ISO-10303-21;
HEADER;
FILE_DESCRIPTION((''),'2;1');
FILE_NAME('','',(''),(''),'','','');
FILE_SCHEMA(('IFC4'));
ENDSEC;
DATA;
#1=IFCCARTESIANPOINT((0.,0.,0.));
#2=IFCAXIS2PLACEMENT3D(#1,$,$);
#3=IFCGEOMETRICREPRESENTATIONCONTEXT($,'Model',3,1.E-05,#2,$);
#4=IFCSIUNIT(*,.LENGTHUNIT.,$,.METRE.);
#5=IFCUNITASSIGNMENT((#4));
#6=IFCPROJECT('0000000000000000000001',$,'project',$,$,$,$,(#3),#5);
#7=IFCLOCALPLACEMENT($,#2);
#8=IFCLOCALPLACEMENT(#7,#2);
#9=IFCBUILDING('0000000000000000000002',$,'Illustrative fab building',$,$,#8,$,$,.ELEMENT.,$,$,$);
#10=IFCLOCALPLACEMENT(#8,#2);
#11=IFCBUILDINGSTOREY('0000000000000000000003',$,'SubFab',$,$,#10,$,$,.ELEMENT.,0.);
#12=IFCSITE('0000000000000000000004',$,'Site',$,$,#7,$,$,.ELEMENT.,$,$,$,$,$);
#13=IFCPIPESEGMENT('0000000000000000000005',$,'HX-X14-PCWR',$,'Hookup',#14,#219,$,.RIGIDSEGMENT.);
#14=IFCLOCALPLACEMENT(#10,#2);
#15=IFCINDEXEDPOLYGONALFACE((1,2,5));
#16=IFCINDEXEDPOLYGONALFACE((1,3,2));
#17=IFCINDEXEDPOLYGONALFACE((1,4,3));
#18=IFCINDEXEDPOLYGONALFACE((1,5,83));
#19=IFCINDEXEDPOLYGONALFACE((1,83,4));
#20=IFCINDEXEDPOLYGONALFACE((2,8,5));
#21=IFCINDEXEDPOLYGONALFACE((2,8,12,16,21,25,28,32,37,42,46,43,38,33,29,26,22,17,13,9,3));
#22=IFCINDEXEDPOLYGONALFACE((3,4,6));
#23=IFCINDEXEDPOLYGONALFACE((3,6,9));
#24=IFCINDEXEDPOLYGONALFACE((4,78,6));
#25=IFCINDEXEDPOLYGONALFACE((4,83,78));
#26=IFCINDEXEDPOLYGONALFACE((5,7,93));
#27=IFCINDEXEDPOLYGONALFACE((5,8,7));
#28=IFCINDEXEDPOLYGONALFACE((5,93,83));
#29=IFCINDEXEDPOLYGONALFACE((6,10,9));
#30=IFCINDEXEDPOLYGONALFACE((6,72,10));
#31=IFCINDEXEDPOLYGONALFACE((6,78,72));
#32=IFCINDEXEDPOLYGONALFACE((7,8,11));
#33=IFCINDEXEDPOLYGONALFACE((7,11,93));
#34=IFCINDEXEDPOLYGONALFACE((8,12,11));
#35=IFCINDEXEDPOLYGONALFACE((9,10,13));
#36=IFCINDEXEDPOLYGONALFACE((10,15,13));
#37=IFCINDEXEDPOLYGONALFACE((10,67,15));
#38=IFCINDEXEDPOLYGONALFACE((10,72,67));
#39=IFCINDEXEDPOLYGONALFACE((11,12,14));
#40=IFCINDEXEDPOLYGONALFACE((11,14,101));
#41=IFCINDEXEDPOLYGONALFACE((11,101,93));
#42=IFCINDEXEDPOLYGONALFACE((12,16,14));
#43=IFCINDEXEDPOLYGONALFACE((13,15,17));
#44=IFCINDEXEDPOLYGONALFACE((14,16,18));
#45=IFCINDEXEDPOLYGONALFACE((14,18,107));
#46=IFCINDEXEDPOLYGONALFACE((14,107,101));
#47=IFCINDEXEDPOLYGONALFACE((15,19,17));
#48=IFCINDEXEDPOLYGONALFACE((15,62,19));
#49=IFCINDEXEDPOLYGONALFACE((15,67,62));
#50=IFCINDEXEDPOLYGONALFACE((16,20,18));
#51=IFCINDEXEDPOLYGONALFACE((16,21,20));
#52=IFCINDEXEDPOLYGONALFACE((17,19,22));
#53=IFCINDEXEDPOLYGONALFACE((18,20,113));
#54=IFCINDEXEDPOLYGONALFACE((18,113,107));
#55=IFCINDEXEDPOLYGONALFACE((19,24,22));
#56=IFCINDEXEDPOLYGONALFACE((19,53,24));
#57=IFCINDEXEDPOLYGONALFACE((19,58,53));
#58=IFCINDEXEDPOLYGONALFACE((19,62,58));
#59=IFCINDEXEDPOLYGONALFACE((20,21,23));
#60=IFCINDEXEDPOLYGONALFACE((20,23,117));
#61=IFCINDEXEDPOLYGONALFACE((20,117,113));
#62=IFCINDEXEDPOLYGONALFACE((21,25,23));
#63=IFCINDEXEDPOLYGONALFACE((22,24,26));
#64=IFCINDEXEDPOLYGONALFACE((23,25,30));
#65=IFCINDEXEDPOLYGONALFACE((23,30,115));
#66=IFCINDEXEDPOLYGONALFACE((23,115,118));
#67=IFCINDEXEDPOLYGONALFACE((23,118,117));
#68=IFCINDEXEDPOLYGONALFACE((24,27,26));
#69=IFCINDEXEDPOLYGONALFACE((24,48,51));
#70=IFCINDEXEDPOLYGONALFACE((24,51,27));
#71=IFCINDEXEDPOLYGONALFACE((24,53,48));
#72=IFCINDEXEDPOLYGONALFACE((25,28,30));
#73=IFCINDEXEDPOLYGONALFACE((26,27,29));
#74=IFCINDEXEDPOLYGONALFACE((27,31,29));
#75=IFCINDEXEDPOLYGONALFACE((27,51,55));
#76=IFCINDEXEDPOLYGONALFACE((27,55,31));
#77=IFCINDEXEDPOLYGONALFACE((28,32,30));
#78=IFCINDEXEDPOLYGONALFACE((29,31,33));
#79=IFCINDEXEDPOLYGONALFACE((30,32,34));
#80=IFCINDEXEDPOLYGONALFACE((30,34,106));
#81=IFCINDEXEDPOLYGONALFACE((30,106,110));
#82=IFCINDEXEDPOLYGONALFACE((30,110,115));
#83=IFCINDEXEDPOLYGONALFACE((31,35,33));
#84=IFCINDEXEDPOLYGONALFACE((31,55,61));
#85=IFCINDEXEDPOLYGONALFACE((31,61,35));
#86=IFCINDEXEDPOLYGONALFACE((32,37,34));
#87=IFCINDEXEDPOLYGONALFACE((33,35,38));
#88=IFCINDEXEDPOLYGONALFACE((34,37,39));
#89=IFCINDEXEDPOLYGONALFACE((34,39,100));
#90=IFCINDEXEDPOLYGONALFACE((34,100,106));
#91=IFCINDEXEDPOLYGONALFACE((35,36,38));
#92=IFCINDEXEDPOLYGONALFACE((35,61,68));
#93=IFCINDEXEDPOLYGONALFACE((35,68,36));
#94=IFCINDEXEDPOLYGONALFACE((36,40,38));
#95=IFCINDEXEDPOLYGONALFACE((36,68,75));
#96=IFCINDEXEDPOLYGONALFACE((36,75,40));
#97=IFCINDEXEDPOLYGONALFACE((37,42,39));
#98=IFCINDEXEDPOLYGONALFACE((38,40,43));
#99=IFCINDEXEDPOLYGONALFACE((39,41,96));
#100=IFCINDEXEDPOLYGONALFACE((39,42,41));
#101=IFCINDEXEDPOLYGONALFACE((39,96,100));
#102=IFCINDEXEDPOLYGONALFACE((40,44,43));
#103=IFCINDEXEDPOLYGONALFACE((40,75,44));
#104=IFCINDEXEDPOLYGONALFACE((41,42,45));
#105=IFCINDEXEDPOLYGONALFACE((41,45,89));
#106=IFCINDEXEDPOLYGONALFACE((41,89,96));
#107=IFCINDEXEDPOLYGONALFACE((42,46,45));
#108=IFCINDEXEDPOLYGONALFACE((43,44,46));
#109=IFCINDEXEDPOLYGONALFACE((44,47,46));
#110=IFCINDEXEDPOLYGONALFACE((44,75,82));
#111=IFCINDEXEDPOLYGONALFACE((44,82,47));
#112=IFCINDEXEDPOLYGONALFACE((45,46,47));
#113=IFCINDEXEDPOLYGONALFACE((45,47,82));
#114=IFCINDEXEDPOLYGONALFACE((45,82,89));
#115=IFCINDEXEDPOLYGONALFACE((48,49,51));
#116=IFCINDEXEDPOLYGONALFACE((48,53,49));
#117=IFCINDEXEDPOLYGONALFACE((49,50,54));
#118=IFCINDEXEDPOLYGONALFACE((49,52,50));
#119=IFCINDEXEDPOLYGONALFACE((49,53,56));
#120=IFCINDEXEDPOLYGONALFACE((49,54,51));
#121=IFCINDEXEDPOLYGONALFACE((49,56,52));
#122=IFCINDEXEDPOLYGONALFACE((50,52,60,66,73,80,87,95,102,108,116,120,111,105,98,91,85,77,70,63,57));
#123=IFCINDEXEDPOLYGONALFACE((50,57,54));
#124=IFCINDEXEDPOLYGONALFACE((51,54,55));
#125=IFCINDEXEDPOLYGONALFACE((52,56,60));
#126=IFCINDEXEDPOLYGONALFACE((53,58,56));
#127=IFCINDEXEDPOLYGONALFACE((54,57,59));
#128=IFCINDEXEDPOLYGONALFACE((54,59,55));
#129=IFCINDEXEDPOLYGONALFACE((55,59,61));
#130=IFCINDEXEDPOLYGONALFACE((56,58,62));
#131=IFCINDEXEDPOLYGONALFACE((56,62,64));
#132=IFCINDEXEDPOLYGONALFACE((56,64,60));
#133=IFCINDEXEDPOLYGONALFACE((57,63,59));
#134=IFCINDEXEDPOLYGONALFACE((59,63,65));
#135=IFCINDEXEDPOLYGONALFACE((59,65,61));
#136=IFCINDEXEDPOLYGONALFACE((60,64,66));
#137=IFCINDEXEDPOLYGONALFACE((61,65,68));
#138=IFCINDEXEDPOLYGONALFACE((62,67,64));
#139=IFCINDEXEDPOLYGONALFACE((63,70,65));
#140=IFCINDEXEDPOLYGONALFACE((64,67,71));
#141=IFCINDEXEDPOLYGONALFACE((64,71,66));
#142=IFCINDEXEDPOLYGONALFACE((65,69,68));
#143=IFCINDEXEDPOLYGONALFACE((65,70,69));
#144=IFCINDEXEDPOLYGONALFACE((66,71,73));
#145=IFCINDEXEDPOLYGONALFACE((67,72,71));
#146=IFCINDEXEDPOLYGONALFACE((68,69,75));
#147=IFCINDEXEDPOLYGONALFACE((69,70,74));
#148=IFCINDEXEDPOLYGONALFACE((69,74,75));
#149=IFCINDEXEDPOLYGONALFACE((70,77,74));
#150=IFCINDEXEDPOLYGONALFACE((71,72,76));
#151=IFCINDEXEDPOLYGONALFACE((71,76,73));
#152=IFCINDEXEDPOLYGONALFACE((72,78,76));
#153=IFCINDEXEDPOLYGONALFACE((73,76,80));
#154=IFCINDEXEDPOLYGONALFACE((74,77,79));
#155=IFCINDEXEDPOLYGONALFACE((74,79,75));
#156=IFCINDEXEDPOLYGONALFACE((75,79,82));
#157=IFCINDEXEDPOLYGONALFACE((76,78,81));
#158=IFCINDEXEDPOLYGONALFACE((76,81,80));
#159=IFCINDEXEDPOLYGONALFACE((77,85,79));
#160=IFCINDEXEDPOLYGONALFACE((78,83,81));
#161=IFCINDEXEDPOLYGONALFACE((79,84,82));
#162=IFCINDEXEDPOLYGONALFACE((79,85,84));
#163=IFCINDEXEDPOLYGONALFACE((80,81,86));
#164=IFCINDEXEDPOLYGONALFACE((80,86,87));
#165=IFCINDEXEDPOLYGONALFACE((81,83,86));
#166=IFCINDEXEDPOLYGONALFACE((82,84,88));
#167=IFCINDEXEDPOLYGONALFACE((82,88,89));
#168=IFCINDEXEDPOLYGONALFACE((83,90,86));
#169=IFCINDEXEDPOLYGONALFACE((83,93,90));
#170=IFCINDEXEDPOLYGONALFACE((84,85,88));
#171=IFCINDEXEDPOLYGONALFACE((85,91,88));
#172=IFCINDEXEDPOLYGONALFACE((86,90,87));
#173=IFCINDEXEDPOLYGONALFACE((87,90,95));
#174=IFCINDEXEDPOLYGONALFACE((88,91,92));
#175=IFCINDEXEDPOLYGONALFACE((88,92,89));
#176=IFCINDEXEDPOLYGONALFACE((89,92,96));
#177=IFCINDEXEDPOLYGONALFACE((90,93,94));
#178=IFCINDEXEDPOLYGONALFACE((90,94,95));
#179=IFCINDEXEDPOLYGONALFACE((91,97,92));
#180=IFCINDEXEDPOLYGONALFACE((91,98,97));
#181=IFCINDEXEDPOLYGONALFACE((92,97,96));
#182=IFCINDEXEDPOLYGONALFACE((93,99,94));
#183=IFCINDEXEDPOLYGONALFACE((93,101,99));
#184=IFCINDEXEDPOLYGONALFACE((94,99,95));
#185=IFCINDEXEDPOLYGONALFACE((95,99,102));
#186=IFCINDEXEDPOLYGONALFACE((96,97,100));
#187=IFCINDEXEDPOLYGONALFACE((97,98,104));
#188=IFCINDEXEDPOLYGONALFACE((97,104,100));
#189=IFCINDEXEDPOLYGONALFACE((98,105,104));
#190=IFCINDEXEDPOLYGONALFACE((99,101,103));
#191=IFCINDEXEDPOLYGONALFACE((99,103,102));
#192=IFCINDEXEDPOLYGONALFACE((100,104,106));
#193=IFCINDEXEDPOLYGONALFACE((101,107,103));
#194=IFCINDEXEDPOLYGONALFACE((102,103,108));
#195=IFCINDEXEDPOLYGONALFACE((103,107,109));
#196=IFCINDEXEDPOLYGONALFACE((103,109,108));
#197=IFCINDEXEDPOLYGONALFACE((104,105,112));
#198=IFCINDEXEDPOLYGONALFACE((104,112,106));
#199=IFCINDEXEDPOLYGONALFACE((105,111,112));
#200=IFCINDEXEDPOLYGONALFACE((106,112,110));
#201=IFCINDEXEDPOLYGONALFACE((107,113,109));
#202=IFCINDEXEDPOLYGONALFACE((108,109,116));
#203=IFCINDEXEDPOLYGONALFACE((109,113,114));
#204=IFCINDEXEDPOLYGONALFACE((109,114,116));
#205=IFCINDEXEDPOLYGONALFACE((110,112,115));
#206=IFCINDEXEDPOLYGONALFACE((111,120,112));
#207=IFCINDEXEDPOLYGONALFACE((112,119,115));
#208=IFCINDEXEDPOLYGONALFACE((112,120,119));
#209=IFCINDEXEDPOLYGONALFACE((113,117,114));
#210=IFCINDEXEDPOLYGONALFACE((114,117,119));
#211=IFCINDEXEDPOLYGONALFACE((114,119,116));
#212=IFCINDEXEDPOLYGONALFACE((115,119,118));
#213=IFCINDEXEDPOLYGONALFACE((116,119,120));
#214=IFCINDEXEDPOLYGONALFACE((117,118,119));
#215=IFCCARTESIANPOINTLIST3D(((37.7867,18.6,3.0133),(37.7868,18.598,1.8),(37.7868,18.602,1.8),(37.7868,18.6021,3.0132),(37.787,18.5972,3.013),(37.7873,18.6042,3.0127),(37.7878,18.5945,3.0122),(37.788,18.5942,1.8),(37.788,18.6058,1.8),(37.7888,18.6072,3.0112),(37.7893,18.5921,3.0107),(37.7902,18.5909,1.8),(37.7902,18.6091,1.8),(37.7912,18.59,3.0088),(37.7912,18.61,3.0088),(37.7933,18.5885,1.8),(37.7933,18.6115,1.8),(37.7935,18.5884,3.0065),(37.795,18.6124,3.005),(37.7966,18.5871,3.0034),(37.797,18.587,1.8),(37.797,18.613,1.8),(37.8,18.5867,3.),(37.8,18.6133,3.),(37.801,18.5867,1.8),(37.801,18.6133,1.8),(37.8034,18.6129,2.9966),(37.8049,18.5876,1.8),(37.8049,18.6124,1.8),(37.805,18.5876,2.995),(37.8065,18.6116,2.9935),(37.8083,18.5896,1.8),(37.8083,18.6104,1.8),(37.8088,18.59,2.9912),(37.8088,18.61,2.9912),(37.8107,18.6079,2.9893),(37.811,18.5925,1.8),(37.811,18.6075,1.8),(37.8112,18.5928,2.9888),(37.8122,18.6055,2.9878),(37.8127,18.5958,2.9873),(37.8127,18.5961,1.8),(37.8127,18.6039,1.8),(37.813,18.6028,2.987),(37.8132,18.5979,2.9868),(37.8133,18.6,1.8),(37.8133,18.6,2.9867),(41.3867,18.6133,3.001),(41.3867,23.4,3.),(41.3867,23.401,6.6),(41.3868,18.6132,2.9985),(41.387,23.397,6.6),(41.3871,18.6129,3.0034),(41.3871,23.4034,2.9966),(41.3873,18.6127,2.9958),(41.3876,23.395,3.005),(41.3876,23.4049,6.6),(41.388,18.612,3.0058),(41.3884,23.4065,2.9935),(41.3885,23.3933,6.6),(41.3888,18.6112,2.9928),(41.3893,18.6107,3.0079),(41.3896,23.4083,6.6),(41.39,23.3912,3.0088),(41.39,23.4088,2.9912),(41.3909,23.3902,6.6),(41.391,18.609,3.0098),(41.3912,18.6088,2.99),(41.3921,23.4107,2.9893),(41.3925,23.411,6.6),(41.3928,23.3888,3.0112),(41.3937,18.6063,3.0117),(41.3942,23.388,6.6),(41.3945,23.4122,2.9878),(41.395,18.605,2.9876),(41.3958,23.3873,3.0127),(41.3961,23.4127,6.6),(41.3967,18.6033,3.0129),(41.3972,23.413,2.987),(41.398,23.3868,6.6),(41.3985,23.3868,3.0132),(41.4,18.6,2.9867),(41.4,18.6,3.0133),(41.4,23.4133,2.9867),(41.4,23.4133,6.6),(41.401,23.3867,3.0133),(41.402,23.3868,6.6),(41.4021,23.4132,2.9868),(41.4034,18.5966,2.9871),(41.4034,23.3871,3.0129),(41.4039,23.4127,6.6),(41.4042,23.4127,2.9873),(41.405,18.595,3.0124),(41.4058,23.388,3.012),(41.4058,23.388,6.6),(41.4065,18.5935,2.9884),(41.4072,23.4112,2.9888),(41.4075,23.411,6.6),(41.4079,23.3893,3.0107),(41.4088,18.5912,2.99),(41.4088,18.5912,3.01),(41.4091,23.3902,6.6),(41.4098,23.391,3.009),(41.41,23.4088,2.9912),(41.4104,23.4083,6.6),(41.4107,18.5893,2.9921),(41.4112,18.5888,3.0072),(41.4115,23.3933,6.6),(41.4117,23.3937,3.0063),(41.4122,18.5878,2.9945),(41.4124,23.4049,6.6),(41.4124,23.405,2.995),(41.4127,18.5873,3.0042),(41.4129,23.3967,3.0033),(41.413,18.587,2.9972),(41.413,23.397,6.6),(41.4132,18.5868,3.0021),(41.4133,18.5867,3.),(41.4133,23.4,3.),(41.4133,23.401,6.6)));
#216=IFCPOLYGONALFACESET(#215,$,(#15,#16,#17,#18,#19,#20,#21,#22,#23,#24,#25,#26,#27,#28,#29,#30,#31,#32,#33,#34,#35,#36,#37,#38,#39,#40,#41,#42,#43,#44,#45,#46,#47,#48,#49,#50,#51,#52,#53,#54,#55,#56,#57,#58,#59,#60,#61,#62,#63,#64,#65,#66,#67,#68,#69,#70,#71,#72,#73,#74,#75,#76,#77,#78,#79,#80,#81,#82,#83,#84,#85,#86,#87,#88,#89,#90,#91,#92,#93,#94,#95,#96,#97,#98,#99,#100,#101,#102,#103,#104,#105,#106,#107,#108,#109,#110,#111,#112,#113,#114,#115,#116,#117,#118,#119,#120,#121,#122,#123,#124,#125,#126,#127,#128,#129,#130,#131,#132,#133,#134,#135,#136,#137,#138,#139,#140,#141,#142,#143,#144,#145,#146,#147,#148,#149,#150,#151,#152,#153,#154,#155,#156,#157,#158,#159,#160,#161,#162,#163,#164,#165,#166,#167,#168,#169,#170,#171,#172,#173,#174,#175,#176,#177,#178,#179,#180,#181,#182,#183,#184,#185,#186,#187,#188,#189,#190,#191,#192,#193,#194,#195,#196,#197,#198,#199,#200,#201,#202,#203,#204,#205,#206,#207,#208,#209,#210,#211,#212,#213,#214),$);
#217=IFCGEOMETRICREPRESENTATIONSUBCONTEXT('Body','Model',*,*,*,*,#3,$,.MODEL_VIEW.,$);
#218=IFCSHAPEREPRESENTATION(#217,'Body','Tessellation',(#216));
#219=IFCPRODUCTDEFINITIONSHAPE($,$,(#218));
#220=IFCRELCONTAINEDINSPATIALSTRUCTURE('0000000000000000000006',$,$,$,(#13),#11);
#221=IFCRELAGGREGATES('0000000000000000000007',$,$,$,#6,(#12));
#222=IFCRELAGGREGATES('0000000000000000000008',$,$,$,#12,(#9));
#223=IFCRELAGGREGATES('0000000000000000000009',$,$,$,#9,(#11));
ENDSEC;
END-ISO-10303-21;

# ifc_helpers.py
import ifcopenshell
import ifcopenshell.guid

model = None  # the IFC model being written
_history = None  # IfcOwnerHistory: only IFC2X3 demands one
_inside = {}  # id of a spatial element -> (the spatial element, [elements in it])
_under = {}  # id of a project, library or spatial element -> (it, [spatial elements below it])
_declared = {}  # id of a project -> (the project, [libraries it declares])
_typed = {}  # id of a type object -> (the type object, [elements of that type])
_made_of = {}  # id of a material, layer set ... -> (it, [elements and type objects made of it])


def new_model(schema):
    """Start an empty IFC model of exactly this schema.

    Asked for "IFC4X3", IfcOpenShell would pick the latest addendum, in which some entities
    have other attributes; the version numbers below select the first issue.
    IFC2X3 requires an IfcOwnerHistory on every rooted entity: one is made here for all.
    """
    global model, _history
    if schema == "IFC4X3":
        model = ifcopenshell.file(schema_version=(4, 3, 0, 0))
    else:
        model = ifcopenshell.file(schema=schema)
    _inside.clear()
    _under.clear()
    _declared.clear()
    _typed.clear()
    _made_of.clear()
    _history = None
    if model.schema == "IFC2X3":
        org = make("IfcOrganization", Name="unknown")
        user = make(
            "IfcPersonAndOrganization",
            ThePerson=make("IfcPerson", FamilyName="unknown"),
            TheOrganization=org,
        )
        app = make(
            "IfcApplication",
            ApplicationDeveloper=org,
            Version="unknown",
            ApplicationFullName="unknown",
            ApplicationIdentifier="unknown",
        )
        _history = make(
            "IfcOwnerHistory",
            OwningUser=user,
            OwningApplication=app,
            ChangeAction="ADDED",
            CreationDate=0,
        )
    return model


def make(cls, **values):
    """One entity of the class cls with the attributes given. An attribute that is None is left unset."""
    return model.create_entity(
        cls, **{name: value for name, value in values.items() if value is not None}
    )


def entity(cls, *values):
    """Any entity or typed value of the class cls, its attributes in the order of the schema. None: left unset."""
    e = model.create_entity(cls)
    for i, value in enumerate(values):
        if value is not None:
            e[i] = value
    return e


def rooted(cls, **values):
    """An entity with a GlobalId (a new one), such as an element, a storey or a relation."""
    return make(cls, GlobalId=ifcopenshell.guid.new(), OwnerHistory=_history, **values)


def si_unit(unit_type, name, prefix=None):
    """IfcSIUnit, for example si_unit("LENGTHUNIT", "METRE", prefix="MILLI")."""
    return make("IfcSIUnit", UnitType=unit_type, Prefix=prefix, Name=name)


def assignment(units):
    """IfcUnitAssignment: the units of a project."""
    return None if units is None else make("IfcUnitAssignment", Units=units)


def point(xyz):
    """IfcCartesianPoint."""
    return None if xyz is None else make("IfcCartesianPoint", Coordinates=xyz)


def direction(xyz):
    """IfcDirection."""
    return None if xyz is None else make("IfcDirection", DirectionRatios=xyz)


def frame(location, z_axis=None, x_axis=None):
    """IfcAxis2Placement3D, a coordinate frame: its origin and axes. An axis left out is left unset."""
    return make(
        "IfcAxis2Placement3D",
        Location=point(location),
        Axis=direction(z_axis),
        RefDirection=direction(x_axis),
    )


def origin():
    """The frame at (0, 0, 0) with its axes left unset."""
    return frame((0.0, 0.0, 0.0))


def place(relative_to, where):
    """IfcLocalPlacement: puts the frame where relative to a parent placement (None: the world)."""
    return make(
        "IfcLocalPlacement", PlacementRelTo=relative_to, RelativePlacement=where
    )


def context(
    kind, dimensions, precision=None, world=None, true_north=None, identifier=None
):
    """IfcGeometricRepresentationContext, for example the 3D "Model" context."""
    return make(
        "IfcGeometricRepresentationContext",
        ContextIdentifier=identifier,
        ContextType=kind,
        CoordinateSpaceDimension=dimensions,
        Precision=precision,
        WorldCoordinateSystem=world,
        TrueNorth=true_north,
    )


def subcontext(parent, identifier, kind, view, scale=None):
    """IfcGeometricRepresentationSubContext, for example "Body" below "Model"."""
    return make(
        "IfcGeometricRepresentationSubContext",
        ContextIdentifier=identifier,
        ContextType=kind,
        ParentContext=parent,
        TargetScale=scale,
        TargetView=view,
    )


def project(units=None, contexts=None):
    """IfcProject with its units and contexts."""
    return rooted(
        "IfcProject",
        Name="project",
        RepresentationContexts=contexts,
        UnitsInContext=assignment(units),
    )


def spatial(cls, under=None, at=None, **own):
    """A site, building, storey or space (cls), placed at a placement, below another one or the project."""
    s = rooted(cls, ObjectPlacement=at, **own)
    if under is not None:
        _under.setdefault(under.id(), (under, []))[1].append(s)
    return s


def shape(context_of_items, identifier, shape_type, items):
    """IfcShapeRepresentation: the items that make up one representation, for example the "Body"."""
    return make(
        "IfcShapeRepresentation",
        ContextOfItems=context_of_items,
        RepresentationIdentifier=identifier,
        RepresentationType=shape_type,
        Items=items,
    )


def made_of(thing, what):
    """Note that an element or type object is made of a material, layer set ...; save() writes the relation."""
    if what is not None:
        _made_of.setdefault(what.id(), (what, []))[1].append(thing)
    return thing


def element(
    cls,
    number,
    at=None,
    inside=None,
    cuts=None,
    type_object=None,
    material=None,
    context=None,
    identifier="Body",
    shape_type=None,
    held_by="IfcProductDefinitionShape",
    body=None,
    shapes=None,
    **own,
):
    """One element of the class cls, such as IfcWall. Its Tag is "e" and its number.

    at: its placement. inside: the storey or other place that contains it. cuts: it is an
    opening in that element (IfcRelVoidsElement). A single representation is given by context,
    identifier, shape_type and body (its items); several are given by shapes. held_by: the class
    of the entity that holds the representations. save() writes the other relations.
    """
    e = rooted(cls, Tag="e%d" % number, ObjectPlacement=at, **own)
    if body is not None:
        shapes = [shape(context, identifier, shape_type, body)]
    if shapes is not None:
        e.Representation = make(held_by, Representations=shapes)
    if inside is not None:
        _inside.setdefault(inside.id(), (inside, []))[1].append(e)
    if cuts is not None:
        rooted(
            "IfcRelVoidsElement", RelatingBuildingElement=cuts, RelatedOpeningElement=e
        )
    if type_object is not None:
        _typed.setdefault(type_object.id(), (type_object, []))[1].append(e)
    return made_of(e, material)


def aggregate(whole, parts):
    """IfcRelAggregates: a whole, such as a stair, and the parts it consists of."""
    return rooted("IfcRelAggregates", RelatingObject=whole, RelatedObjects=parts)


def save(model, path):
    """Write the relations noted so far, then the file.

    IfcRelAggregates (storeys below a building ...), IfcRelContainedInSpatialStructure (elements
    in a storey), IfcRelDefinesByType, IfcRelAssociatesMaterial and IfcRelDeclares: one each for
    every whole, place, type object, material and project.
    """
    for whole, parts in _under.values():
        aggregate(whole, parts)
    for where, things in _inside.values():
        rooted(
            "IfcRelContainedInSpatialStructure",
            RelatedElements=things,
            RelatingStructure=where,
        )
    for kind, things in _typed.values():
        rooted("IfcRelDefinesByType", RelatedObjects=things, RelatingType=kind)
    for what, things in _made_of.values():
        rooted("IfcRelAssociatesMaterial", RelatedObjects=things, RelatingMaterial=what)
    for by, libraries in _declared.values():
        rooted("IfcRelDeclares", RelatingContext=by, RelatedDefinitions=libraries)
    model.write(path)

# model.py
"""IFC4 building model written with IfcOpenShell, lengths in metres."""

from ifc_helpers import new_model, entity, si_unit, origin, place, context, subcontext, project, spatial, element, save


model = new_model("IFC4")

# Units and contexts
model_context = context("Model", 3, precision=1e-05, world=origin())
body_context = subcontext(model_context, "Body", "Model", "MODEL_VIEW")
ifc_project = project(units=[si_unit("LENGTHUNIT", "METRE")], contexts=[model_context])

# Site, building, storey
site_placement = place(None, origin())
site = spatial("IfcSite", under=ifc_project, at=site_placement, Name="Site", CompositionType="ELEMENT")
building_placement = place(site_placement, origin())
building = spatial("IfcBuilding", under=site, at=building_placement, Name="Illustrative fab building", CompositionType="ELEMENT")
storey_placement = place(building_placement, origin())
storey = spatial("IfcBuildingStorey", under=building, at=storey_placement, Name="SubFab", CompositionType="ELEMENT", Elevation=0.0)

# Pipe segment
pipe_segment_1_placement = place(storey_placement, origin())
element("IfcPipeSegment", 1, at=pipe_segment_1_placement, inside=storey, Name="HX-X14-PCWR", ObjectType="Hookup", PredefinedType="RIGIDSEGMENT", context=body_context, shape_type="AdvancedSweptSolid", body=[
    entity("IfcSweptDiskSolid", entity("IfcPolyline", [entity("IfcCartesianPoint", [37.8, 18.6, 1.8]), entity("IfcCartesianPoint", [37.8, 18.6, 3.0]), entity("IfcCartesianPoint", [41.4, 18.6, 3.0]), entity("IfcCartesianPoint", [41.4, 23.4, 3.0]), entity("IfcCartesianPoint", [41.4, 23.4, 6.6])]), 0.0133),
])

save(model, "model.ifc")
